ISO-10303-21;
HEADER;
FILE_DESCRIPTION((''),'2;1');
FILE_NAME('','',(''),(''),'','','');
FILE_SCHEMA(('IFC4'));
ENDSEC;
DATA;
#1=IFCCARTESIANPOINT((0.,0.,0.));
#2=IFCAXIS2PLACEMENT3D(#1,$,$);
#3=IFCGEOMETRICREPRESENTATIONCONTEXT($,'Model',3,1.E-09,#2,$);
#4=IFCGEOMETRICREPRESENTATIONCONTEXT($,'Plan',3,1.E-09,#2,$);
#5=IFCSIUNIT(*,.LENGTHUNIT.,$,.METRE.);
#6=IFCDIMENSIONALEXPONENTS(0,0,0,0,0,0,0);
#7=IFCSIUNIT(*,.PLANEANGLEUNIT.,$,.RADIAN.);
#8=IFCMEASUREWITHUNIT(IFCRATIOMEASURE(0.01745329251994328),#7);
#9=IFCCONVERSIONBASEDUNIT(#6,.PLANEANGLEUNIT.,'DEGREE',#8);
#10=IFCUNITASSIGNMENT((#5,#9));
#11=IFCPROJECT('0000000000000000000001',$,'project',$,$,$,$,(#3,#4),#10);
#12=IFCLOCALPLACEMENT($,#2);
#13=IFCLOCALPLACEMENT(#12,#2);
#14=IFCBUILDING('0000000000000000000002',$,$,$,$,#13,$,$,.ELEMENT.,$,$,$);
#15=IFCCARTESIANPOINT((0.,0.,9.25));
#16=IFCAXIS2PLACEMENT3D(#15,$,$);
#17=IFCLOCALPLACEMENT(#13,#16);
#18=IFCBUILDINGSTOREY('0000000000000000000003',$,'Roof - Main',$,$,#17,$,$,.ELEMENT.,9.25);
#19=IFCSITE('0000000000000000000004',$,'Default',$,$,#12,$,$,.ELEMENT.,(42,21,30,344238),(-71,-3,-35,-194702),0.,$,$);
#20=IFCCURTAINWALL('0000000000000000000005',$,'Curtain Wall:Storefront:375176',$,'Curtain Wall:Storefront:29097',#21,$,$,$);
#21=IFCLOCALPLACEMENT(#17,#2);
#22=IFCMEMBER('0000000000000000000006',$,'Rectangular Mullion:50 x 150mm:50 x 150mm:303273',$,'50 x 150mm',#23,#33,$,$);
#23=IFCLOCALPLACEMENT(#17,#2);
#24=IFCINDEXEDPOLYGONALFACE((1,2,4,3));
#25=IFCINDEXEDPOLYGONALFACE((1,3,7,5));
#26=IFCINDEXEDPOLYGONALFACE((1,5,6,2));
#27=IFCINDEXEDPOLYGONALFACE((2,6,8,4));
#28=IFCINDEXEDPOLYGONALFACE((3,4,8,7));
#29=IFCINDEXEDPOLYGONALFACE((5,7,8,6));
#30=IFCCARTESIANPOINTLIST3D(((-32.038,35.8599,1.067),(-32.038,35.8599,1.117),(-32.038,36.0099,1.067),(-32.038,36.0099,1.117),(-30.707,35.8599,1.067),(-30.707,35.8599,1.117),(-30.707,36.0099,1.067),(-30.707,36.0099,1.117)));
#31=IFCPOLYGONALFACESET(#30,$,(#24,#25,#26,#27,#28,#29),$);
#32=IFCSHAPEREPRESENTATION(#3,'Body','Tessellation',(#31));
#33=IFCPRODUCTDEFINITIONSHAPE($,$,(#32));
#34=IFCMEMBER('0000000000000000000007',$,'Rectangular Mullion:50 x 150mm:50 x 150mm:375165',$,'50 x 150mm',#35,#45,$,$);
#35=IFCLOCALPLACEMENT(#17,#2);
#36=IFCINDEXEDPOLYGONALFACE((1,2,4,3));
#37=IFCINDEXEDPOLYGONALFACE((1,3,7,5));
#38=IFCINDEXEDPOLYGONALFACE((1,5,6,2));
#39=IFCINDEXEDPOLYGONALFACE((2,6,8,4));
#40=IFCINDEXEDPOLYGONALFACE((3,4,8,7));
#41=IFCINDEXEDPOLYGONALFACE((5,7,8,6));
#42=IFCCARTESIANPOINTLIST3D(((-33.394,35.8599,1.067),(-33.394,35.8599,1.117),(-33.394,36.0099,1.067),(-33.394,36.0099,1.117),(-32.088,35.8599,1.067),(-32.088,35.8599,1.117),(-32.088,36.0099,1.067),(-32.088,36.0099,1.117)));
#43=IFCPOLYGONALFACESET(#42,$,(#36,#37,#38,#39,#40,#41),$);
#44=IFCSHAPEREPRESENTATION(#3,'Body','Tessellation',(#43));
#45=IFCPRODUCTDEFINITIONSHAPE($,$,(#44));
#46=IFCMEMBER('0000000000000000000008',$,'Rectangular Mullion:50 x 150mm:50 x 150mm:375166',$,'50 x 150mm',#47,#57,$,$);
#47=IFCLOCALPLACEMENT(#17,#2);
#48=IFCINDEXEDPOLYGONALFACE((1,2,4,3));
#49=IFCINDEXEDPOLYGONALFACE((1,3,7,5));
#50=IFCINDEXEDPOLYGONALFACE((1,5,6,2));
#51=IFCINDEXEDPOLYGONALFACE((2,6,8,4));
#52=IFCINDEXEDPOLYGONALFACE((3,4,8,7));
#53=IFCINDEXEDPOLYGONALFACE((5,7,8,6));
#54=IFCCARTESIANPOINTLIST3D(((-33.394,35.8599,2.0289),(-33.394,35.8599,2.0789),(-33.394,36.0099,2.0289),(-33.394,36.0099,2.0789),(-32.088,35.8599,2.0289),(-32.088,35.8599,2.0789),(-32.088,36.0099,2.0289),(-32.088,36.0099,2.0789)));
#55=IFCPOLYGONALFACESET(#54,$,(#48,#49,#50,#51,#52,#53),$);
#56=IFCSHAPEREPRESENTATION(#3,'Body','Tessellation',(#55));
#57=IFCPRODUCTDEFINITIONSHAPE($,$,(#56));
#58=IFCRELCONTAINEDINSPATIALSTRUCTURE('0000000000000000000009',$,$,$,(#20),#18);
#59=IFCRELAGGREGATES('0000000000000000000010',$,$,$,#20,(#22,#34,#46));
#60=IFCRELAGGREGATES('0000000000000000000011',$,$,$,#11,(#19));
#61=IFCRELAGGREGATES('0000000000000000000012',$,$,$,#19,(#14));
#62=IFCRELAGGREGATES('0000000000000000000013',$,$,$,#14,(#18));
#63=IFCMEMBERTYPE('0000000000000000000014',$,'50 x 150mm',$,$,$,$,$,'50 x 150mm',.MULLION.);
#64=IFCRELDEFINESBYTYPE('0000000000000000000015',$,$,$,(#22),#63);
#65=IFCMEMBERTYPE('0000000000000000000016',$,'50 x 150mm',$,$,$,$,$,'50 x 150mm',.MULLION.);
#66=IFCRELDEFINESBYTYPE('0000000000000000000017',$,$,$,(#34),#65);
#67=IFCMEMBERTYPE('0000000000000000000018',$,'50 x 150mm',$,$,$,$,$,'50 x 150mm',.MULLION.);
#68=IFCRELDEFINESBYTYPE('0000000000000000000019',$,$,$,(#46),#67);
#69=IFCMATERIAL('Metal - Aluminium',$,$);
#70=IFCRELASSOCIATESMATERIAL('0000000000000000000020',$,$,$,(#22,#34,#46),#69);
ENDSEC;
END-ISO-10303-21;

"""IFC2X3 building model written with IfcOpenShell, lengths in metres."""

from ifc_helpers import new_model, entity, si_unit, converted_unit, frame, origin, origin_2d_with_axis, place, context, project, spatial, rectangle, extrude, source, transform, mapped, material, type_object, type_shapes, element, aggregate, save


model = new_model("IFC2X3")

# Units and contexts
model_context = context("Model", 3, precision=1e-09, world=origin())
plan_context = context("Plan", 3, precision=1e-09, world=origin())
ifc_project = project(units=[si_unit("LENGTHUNIT", "METRE"), converted_unit("PLANEANGLEUNIT", "DEGREE", entity("IfcRatioMeasure", 0.01745329251994328), si_unit("PLANEANGLEUNIT", "RADIAN"), dimensions=[0, 0, 0, 0, 0, 0, 0])], contexts=[model_context, plan_context])

# Site, building, storey
site_placement = place(None, origin())
site = spatial("IfcSite", under=ifc_project, at=site_placement, Name="Default", CompositionType="ELEMENT", RefLatitude=(42, 21, 30, 344238), RefLongitude=(-71, -3, -35, -194702), RefElevation=0.0)
building_placement = place(site_placement, origin())
building = spatial("IfcBuilding", under=site, at=building_placement, CompositionType="ELEMENT")
storey_placement = place(building_placement, frame((0.0, 0.0, 9.25)))
storey = spatial("IfcBuildingStorey", under=building, at=storey_placement, Name="Roof - Main", CompositionType="ELEMENT", Elevation=9.25)

# Shared definitions
ifc_material_1 = material(Name="Metal - Aluminium")

# Curtain wall
curtain_wall_1_placement = place(storey_placement, origin())
curtain_wall_1 = element("IfcCurtainWall", 1, at=curtain_wall_1_placement, inside=storey, Name="Curtain Wall:Storefront:375176", ObjectType="Curtain Wall:Storefront:29097")

# Members
member_type_1 = type_object("IfcMemberType", Name="50 x 150mm", ElementType="50 x 150mm", PredefinedType="MULLION")
shared_shape_1 = source(origin(), model_context, "Body", "SweptSolid", [
    extrude(rectangle(XDim=0.05, YDim=0.15, at=origin_2d_with_axis()), frame((-0.025, 0.0, -1.331), z_axis=(0.0, 0.0, 1.0), x_axis=(-1.0, 0.0, 0.0)), (0.0, 0.0, 1.0), 1.331),
])
type_shapes(member_type_1, [shared_shape_1])
member_1_placement = place(storey_placement, frame((-32.038, 35.9349, 1.067), z_axis=(-1.0, 0.0, 0.0), x_axis=(0.0, 0.0, -1.0)))
member_1 = element("IfcMember", 2, at=member_1_placement, type_object=member_type_1, material=ifc_material_1, Name="Rectangular Mullion:50 x 150mm:50 x 150mm:303273", ObjectType="50 x 150mm", context=model_context, shape_type="MappedRepresentation", body=[
    mapped(shared_shape_1, transform((0.0, 0.0, 0.0), scale=1.0)),
])
member_type_2 = type_object("IfcMemberType", Name="50 x 150mm", ElementType="50 x 150mm", PredefinedType="MULLION")
shared_shape_2 = source(origin(), model_context, "Body", "SweptSolid", [
    extrude(rectangle(XDim=0.05, YDim=0.15, at=origin_2d_with_axis()), frame((-0.025, 0.0, -1.306), z_axis=(0.0, 0.0, 1.0), x_axis=(-1.0, 0.0, 0.0)), (0.0, 0.0, 1.0), 1.306),
])
type_shapes(member_type_2, [shared_shape_2])
member_2_placement = place(storey_placement, frame((-33.394, 35.9349, 1.067), z_axis=(-1.0, 0.0, 0.0), x_axis=(0.0, 0.0, -1.0)))
member_2 = element("IfcMember", 3, at=member_2_placement, type_object=member_type_2, material=ifc_material_1, Name="Rectangular Mullion:50 x 150mm:50 x 150mm:375165", ObjectType="50 x 150mm", context=model_context, shape_type="MappedRepresentation", body=[
    mapped(shared_shape_2, transform((0.0, 0.0, 0.0), scale=1.0)),
])
member_type_3 = type_object("IfcMemberType", Name="50 x 150mm", ElementType="50 x 150mm", PredefinedType="MULLION")
shared_shape_3 = source(origin(), model_context, "Body", "SweptSolid", [
    extrude(rectangle(XDim=0.05, YDim=0.15, at=origin_2d_with_axis()), frame((0.0, 0.0, -1.306), z_axis=(0.0, 0.0, 1.0), x_axis=(-1.0, 0.0, 0.0)), (0.0, 0.0, 1.0), 1.306),
])
type_shapes(member_type_3, [shared_shape_3])
member_3_placement = place(storey_placement, frame((-32.088, 35.9349, 2.0539), z_axis=(1.0, 0.0, 0.0), x_axis=(0.0, 0.0, 1.0)))
member_3 = element("IfcMember", 4, at=member_3_placement, type_object=member_type_3, material=ifc_material_1, Name="Rectangular Mullion:50 x 150mm:50 x 150mm:375166", ObjectType="50 x 150mm", context=model_context, shape_type="MappedRepresentation", body=[
    mapped(shared_shape_3, transform((0.0, 0.0, 0.0), scale=1.0)),
])

aggregate(curtain_wall_1, [member_1, member_2, member_3])

save(model, "model.ifc")
